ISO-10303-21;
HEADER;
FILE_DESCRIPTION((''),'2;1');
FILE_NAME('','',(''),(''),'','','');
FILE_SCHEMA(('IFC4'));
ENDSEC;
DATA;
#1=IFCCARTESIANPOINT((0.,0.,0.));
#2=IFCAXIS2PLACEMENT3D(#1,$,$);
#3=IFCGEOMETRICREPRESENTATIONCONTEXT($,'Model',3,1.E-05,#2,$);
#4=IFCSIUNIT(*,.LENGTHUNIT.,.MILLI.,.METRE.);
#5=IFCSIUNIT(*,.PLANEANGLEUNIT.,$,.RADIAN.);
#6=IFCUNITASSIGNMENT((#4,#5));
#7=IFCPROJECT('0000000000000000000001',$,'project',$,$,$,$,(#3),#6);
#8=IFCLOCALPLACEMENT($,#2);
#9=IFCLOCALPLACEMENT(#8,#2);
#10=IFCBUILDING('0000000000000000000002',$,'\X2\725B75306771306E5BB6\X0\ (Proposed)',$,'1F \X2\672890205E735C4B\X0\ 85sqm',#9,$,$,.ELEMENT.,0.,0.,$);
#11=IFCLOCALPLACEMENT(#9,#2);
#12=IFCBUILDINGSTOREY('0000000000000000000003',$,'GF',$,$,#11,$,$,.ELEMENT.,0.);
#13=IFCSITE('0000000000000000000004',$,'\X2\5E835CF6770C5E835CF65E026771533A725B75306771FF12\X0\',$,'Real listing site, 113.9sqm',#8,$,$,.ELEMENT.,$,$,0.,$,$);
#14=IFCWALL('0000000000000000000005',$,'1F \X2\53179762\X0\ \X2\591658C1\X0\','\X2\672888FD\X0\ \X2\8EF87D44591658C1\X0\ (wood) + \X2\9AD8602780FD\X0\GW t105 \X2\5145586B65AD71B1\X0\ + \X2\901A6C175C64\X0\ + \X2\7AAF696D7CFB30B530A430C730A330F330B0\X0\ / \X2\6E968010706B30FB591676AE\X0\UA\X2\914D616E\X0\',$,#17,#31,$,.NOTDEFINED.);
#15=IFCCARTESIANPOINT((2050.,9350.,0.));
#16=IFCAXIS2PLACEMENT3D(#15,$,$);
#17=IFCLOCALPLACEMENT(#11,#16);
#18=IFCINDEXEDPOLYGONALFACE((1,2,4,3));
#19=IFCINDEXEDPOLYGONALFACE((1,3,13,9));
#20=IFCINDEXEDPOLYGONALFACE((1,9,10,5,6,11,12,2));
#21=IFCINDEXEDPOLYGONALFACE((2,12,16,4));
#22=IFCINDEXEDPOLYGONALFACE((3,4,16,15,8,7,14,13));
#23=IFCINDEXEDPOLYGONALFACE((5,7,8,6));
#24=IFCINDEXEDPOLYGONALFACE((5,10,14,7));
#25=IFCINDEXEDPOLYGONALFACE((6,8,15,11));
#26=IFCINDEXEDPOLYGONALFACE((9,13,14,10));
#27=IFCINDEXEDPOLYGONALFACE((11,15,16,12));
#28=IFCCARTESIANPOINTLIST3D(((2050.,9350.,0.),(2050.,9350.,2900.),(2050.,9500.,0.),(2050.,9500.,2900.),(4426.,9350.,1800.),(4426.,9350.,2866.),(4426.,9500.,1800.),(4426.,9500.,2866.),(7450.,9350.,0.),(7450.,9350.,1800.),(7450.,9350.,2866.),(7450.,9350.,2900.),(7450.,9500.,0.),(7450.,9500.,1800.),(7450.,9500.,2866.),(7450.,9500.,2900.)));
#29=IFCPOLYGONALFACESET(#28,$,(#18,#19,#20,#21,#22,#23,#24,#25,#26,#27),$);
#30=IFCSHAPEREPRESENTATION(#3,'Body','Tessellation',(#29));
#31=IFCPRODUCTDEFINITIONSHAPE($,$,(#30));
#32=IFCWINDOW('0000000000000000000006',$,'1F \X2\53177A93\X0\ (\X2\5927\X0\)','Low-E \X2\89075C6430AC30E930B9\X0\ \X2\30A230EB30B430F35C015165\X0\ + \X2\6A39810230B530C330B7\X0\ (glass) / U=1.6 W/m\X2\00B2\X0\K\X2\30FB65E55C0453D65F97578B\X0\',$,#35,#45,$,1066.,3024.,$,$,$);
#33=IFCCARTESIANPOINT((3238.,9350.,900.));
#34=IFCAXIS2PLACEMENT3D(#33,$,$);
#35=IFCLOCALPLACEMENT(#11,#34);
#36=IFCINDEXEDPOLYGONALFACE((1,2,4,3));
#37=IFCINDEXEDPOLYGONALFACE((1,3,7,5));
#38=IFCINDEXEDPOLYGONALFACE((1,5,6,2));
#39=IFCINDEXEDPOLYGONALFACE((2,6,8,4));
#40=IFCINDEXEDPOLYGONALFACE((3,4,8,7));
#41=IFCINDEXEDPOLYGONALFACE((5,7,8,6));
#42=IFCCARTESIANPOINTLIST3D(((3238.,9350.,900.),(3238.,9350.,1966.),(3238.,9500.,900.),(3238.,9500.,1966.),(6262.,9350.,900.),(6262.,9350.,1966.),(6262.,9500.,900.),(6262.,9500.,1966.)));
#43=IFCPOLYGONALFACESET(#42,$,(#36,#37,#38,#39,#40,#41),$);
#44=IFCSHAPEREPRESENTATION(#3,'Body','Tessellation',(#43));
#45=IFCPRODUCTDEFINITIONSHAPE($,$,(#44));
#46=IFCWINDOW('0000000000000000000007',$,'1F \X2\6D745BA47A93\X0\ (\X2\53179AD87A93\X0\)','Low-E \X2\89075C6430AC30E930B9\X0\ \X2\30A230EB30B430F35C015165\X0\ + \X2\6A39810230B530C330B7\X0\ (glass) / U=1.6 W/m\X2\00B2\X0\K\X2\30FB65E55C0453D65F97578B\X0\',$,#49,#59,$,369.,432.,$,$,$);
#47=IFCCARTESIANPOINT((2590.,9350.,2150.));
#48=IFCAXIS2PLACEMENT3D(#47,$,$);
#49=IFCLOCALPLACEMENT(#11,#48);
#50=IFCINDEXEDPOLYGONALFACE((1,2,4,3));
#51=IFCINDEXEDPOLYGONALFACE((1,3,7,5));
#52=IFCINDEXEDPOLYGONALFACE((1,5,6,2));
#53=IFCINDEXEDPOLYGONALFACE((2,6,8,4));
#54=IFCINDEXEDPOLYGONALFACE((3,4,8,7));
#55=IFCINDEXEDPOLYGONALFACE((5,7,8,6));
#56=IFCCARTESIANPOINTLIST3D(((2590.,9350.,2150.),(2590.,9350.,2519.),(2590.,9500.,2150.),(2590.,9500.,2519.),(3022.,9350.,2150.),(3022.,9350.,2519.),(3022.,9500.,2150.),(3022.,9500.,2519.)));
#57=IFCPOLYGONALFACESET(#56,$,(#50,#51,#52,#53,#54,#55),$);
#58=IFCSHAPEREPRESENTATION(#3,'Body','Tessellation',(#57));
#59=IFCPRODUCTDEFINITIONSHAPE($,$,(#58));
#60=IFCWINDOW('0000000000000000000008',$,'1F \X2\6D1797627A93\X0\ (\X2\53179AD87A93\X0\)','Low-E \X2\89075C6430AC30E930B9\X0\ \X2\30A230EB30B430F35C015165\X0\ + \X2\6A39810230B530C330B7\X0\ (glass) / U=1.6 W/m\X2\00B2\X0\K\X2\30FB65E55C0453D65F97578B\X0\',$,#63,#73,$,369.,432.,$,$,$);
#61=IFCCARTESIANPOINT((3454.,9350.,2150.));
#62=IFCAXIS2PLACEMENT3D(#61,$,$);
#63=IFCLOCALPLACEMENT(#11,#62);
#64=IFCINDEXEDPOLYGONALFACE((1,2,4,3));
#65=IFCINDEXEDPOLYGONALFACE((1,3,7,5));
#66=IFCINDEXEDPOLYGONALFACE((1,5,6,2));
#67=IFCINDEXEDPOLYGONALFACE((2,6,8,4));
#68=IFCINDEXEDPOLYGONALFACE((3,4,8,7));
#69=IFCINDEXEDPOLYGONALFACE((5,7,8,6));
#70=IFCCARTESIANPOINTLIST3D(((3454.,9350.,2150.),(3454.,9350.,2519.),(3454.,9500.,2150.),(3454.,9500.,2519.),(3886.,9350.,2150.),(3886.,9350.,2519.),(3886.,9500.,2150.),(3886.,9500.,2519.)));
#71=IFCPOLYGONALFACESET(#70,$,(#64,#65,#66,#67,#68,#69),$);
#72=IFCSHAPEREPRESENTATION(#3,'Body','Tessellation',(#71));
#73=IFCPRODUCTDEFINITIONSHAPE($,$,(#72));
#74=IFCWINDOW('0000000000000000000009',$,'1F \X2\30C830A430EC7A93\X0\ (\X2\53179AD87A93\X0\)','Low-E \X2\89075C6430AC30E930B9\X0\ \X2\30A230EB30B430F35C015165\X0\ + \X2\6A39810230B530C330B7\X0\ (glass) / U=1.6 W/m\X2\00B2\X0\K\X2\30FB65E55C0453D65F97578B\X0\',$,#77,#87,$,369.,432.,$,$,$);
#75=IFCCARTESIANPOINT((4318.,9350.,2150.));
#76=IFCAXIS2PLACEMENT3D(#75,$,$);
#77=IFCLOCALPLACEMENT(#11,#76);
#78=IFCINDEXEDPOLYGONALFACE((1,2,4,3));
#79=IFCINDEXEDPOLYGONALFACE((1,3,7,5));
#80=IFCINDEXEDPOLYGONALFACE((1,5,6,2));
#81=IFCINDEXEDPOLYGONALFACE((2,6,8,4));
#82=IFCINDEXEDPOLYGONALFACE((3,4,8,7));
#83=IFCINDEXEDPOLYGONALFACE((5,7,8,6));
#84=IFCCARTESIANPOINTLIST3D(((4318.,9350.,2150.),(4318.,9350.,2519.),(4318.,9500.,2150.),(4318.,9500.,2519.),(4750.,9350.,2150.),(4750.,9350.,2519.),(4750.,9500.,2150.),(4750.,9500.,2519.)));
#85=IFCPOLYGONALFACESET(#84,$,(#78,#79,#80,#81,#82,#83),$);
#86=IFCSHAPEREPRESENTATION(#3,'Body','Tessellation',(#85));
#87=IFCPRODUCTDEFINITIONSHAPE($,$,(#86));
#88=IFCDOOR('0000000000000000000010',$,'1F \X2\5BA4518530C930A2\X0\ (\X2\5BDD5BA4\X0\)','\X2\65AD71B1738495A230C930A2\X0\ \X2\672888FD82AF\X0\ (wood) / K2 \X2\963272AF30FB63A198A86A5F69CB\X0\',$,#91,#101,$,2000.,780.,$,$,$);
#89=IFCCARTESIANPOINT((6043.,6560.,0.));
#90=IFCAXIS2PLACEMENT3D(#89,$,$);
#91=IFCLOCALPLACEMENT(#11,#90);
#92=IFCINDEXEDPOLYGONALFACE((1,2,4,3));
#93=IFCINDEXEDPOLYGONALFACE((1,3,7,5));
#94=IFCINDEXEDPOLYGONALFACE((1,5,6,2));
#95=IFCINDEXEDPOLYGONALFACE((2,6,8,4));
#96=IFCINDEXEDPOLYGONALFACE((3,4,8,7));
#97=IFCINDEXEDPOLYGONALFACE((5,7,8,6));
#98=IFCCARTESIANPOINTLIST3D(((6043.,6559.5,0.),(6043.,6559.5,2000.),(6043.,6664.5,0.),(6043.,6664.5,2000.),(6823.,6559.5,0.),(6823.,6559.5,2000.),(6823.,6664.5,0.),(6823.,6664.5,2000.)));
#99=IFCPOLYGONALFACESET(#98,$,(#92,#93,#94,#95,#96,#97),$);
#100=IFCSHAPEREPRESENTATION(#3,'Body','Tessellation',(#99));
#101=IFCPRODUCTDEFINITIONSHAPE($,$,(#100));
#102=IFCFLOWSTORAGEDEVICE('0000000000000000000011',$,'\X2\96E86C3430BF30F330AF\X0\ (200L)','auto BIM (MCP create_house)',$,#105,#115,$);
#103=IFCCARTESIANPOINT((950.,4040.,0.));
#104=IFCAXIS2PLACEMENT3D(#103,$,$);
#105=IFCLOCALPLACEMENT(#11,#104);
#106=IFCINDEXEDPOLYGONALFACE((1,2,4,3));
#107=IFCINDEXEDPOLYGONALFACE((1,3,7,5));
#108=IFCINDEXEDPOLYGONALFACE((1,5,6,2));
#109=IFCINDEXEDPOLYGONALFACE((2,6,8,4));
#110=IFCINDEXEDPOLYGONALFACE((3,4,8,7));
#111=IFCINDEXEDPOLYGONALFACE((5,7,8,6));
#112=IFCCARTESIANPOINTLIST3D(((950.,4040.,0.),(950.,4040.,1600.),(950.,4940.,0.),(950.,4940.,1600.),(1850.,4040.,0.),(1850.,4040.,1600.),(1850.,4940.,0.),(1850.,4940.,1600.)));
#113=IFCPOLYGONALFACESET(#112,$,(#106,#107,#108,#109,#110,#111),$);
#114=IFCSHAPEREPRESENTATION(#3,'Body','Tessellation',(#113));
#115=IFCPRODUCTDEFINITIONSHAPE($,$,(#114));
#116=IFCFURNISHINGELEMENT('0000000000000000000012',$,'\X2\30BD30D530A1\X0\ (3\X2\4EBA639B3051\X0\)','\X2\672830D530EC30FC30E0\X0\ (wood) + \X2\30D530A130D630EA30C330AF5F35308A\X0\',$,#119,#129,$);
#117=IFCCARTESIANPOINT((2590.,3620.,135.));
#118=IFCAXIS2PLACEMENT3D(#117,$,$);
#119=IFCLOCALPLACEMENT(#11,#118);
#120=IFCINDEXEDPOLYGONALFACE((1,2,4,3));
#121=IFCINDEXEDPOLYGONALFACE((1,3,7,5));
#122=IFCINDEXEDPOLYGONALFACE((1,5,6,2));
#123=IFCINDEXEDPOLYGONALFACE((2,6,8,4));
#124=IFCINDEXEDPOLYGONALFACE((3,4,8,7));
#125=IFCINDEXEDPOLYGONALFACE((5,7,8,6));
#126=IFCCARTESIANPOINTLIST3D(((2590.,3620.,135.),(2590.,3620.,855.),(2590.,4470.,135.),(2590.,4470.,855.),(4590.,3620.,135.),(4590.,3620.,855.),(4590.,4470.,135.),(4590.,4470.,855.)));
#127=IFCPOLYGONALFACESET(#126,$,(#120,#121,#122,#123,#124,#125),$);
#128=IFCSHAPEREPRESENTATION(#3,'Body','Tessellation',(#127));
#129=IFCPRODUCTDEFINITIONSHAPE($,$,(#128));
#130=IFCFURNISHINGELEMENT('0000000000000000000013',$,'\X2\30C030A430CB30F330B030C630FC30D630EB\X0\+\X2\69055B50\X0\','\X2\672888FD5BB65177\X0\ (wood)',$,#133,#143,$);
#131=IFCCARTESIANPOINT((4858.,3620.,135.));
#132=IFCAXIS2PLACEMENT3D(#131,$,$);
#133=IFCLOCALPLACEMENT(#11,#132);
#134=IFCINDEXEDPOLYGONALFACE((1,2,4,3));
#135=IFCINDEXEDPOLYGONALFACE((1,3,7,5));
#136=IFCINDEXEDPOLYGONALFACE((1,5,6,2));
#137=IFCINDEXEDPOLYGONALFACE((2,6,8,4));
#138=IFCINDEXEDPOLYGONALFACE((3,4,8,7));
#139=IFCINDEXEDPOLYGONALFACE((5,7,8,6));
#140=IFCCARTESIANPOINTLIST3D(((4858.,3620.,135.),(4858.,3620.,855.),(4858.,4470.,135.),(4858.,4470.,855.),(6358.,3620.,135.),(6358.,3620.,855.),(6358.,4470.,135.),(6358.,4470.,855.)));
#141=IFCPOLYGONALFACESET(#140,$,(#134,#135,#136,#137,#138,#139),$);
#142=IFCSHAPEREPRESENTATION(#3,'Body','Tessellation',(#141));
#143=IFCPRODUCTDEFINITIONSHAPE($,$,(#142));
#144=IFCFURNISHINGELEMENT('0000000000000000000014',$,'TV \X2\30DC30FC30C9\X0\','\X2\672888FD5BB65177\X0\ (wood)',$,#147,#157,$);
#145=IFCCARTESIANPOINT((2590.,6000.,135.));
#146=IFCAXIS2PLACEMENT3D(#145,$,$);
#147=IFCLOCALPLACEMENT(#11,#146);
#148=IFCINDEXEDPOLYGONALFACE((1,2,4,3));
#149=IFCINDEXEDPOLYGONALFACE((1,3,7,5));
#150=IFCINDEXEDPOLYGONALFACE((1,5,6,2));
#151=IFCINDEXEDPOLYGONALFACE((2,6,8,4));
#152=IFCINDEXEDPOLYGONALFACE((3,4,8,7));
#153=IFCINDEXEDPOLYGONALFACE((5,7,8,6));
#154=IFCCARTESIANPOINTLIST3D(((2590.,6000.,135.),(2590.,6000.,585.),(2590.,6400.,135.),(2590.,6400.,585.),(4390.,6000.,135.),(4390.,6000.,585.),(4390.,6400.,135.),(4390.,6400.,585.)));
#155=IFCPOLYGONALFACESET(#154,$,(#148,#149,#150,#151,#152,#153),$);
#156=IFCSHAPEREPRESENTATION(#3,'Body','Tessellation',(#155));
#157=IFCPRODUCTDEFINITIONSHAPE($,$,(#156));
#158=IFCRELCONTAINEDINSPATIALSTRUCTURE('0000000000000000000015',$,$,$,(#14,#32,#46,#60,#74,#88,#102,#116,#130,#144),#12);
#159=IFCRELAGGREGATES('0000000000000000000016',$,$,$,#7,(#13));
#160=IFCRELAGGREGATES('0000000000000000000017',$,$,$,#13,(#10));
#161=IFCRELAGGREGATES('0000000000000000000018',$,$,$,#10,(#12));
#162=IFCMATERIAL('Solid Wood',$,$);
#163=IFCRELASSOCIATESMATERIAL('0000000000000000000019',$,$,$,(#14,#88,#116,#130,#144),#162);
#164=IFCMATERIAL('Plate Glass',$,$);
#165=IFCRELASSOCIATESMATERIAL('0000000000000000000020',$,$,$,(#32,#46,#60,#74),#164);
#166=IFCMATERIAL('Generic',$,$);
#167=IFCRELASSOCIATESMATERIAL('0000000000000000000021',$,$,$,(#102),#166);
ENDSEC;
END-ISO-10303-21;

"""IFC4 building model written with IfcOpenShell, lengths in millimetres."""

from ifc_helpers import new_model, si_unit, frame, frame_2d, origin, place, context, project, spatial, rectangle, extrude, material, element, fill, save


model = new_model("IFC4")

# Units and contexts
model_context = context("Model", 3, precision=1e-05, world=origin())
ifc_project = project(units=[si_unit("LENGTHUNIT", "METRE", prefix="MILLI"), si_unit("PLANEANGLEUNIT", "RADIAN")], contexts=[model_context])

# Site, building, storey
site_placement = place(None, origin())
site = spatial("IfcSite", under=ifc_project, at=site_placement, Name="広島県広島市東区牛田東２", ObjectType="Real listing site, 113.9sqm", CompositionType="ELEMENT", RefElevation=0.0)
building_placement = place(site_placement, origin())
building = spatial("IfcBuilding", under=site, at=building_placement, Name="牛田東の家 (Proposed)", ObjectType="1F 木造平屋 85sqm", CompositionType="ELEMENT", ElevationOfRefHeight=0.0, ElevationOfTerrain=0.0)
storey_placement = place(building_placement, origin())
storey = spatial("IfcBuildingStorey", under=building, at=storey_placement, Name="GF", CompositionType="ELEMENT", Elevation=0.0)

# Wall, openings, windows
ifc_material_1 = material(Name="Solid Wood")
wall_1_placement = place(storey_placement, frame((2050.0, 9350.0, 0.0)))
wall_1 = element("IfcWall", 1, at=wall_1_placement, inside=storey, material=ifc_material_1, Name="1F 北面 外壁", Description="木製 軸組外壁 (wood) + 高性能GW t105 充填断熱 + 通気層 + 窯業系サイディング / 準耐火・外皮UA配慮", PredefinedType="NOTDEFINED", context=model_context, shape_type="SweptSolid", body=[
    extrude(rectangle(XDim=5400.0, YDim=150.0, at=frame_2d((2700.0, 75.0))), frame((2050.0, 9350.0, 0.0)), (0.0, 0.0, 1.0), 2900.0),
])
opening_1_placement = place(storey_placement, frame((3238.0, 9350.0, 900.0)))
opening_1 = element("IfcOpeningElement", 2, at=opening_1_placement, cuts=wall_1, PredefinedType="NOTDEFINED", context=model_context, shape_type="SweptSolid", body=[
    extrude(rectangle(XDim=3024.0, YDim=150.0, at=frame_2d((1512.0, 75.0))), frame((3238.0, 9350.0, 900.0)), (0.0, 0.0, 1.0), 1066.0),
])
opening_2_placement = place(storey_placement, frame((2590.0, 9350.0, 2150.0)))
opening_2 = element("IfcOpeningElement", 3, at=opening_2_placement, cuts=wall_1, PredefinedType="NOTDEFINED", context=model_context, shape_type="SweptSolid", body=[
    extrude(rectangle(XDim=432.0, YDim=150.0, at=frame_2d((216.0, 75.0))), frame((2590.0, 9350.0, 2150.0)), (0.0, 0.0, 1.0), 369.0),
])
opening_3_placement = place(storey_placement, frame((3454.0, 9350.0, 2150.0)))
opening_3 = element("IfcOpeningElement", 4, at=opening_3_placement, cuts=wall_1, PredefinedType="NOTDEFINED", context=model_context, shape_type="SweptSolid", body=[
    extrude(rectangle(XDim=432.0, YDim=150.0, at=frame_2d((216.0, 75.0))), frame((3454.0, 9350.0, 2150.0)), (0.0, 0.0, 1.0), 369.0),
])
opening_4_placement = place(storey_placement, frame((4318.0, 9350.0, 2150.0)))
opening_4 = element("IfcOpeningElement", 5, at=opening_4_placement, cuts=wall_1, PredefinedType="NOTDEFINED", context=model_context, shape_type="SweptSolid", body=[
    extrude(rectangle(XDim=432.0, YDim=150.0, at=frame_2d((216.0, 75.0))), frame((4318.0, 9350.0, 2150.0)), (0.0, 0.0, 1.0), 369.0),
])
ifc_material_2 = material(Name="Plate Glass")
window_1_placement = place(storey_placement, frame((3238.0, 9350.0, 900.0)))
window_1 = element("IfcWindow", 6, at=window_1_placement, inside=storey, material=ifc_material_2, Name="1F 北窓 (大)", Description="Low-E 複層ガラス アルゴン封入 + 樹脂サッシ (glass) / U=1.6 W/m²K・日射取得型", OverallHeight=1066.0, OverallWidth=3024.0, context=model_context, shape_type="SweptSolid", body=[
    extrude(rectangle(XDim=3024.0, YDim=150.0, at=frame_2d((1512.0, 75.0))), frame((3238.0, 9350.0, 900.0)), (0.0, 0.0, 1.0), 1066.0),
])
fill(opening_1, window_1)
window_2_placement = place(storey_placement, frame((2590.0, 9350.0, 2150.0)))
window_2 = element("IfcWindow", 7, at=window_2_placement, inside=storey, material=ifc_material_2, Name="1F 浴室窓 (北高窓)", Description="Low-E 複層ガラス アルゴン封入 + 樹脂サッシ (glass) / U=1.6 W/m²K・日射取得型", OverallHeight=369.0, OverallWidth=432.0, context=model_context, shape_type="SweptSolid", body=[
    extrude(rectangle(XDim=432.0, YDim=150.0, at=frame_2d((216.0, 75.0))), frame((2590.0, 9350.0, 2150.0)), (0.0, 0.0, 1.0), 369.0),
])
fill(opening_2, window_2)
window_3_placement = place(storey_placement, frame((3454.0, 9350.0, 2150.0)))
window_3 = element("IfcWindow", 8, at=window_3_placement, inside=storey, material=ifc_material_2, Name="1F 洗面窓 (北高窓)", Description="Low-E 複層ガラス アルゴン封入 + 樹脂サッシ (glass) / U=1.6 W/m²K・日射取得型", OverallHeight=369.0, OverallWidth=432.0, context=model_context, shape_type="SweptSolid", body=[
    extrude(rectangle(XDim=432.0, YDim=150.0, at=frame_2d((216.0, 75.0))), frame((3454.0, 9350.0, 2150.0)), (0.0, 0.0, 1.0), 369.0),
])
fill(opening_3, window_3)
window_4_placement = place(storey_placement, frame((4318.0, 9350.0, 2150.0)))
window_4 = element("IfcWindow", 9, at=window_4_placement, inside=storey, material=ifc_material_2, Name="1F トイレ窓 (北高窓)", Description="Low-E 複層ガラス アルゴン封入 + 樹脂サッシ (glass) / U=1.6 W/m²K・日射取得型", OverallHeight=369.0, OverallWidth=432.0, context=model_context, shape_type="SweptSolid", body=[
    extrude(rectangle(XDim=432.0, YDim=150.0, at=frame_2d((216.0, 75.0))), frame((4318.0, 9350.0, 2150.0)), (0.0, 0.0, 1.0), 369.0),
])
fill(opening_4, window_4)

# Door
door_1_placement = place(storey_placement, frame((6043.0, 6560.0, 0.0)))
element("IfcDoor", 10, at=door_1_placement, inside=storey, material=ifc_material_1, Name="1F 室内ドア (寝室)", Description="断熱玄関ドア 木製芯 (wood) / K2 防犯・採風機構", OverallHeight=2000.0, OverallWidth=780.0, context=model_context, shape_type="SweptSolid", body=[
    extrude(rectangle(XDim=780.0, YDim=105.0, at=frame_2d((390.0, 52.0))), frame((6043.0, 6560.0, 0.0)), (0.0, 0.0, 1.0), 2000.0),
])

# Flow storage device
ifc_material_3 = material(Name="Generic")
flow_storage_device_placement = place(storey_placement, frame((950.0, 4040.0, 0.0)))
element("IfcFlowStorageDevice", 11, at=flow_storage_device_placement, inside=storey, material=ifc_material_3, Name="雨水タンク (200L)", Description="auto BIM (MCP create_house)", context=model_context, shape_type="SweptSolid", body=[
    extrude(rectangle(XDim=900.0, YDim=900.0, at=frame_2d((450.0, 450.0))), frame((950.0, 4040.0, 0.0)), (0.0, 0.0, 1.0), 1600.0),
])

# Furnishing elements
furnishing_1_placement = place(storey_placement, frame((2590.0, 3620.0, 135.0)))
element("IfcFurnishingElement", 12, at=furnishing_1_placement, inside=storey, material=ifc_material_1, Name="ソファ (3人掛け)", Description="木フレーム (wood) + ファブリック張り", context=model_context, shape_type="SweptSolid", body=[
    extrude(rectangle(XDim=2000.0, YDim=850.0, at=frame_2d((1000.0, 425.0))), frame((2590.0, 3620.0, 135.0)), (0.0, 0.0, 1.0), 720.0),
])
furnishing_2_placement = place(storey_placement, frame((4858.0, 3620.0, 135.0)))
element("IfcFurnishingElement", 13, at=furnishing_2_placement, inside=storey, material=ifc_material_1, Name="ダイニングテーブル+椅子", Description="木製家具 (wood)", context=model_context, shape_type="SweptSolid", body=[
    extrude(rectangle(XDim=1500.0, YDim=850.0, at=frame_2d((750.0, 425.0))), frame((4858.0, 3620.0, 135.0)), (0.0, 0.0, 1.0), 720.0),
])
furnishing_3_placement = place(storey_placement, frame((2590.0, 6000.0, 135.0)))
element("IfcFurnishingElement", 14, at=furnishing_3_placement, inside=storey, material=ifc_material_1, Name="TV ボード", Description="木製家具 (wood)", context=model_context, shape_type="SweptSolid", body=[
    extrude(rectangle(XDim=1800.0, YDim=400.0, at=frame_2d((900.0, 200.0))), frame((2590.0, 6000.0, 135.0)), (0.0, 0.0, 1.0), 450.0),
])

save(model, "model.ifc")
